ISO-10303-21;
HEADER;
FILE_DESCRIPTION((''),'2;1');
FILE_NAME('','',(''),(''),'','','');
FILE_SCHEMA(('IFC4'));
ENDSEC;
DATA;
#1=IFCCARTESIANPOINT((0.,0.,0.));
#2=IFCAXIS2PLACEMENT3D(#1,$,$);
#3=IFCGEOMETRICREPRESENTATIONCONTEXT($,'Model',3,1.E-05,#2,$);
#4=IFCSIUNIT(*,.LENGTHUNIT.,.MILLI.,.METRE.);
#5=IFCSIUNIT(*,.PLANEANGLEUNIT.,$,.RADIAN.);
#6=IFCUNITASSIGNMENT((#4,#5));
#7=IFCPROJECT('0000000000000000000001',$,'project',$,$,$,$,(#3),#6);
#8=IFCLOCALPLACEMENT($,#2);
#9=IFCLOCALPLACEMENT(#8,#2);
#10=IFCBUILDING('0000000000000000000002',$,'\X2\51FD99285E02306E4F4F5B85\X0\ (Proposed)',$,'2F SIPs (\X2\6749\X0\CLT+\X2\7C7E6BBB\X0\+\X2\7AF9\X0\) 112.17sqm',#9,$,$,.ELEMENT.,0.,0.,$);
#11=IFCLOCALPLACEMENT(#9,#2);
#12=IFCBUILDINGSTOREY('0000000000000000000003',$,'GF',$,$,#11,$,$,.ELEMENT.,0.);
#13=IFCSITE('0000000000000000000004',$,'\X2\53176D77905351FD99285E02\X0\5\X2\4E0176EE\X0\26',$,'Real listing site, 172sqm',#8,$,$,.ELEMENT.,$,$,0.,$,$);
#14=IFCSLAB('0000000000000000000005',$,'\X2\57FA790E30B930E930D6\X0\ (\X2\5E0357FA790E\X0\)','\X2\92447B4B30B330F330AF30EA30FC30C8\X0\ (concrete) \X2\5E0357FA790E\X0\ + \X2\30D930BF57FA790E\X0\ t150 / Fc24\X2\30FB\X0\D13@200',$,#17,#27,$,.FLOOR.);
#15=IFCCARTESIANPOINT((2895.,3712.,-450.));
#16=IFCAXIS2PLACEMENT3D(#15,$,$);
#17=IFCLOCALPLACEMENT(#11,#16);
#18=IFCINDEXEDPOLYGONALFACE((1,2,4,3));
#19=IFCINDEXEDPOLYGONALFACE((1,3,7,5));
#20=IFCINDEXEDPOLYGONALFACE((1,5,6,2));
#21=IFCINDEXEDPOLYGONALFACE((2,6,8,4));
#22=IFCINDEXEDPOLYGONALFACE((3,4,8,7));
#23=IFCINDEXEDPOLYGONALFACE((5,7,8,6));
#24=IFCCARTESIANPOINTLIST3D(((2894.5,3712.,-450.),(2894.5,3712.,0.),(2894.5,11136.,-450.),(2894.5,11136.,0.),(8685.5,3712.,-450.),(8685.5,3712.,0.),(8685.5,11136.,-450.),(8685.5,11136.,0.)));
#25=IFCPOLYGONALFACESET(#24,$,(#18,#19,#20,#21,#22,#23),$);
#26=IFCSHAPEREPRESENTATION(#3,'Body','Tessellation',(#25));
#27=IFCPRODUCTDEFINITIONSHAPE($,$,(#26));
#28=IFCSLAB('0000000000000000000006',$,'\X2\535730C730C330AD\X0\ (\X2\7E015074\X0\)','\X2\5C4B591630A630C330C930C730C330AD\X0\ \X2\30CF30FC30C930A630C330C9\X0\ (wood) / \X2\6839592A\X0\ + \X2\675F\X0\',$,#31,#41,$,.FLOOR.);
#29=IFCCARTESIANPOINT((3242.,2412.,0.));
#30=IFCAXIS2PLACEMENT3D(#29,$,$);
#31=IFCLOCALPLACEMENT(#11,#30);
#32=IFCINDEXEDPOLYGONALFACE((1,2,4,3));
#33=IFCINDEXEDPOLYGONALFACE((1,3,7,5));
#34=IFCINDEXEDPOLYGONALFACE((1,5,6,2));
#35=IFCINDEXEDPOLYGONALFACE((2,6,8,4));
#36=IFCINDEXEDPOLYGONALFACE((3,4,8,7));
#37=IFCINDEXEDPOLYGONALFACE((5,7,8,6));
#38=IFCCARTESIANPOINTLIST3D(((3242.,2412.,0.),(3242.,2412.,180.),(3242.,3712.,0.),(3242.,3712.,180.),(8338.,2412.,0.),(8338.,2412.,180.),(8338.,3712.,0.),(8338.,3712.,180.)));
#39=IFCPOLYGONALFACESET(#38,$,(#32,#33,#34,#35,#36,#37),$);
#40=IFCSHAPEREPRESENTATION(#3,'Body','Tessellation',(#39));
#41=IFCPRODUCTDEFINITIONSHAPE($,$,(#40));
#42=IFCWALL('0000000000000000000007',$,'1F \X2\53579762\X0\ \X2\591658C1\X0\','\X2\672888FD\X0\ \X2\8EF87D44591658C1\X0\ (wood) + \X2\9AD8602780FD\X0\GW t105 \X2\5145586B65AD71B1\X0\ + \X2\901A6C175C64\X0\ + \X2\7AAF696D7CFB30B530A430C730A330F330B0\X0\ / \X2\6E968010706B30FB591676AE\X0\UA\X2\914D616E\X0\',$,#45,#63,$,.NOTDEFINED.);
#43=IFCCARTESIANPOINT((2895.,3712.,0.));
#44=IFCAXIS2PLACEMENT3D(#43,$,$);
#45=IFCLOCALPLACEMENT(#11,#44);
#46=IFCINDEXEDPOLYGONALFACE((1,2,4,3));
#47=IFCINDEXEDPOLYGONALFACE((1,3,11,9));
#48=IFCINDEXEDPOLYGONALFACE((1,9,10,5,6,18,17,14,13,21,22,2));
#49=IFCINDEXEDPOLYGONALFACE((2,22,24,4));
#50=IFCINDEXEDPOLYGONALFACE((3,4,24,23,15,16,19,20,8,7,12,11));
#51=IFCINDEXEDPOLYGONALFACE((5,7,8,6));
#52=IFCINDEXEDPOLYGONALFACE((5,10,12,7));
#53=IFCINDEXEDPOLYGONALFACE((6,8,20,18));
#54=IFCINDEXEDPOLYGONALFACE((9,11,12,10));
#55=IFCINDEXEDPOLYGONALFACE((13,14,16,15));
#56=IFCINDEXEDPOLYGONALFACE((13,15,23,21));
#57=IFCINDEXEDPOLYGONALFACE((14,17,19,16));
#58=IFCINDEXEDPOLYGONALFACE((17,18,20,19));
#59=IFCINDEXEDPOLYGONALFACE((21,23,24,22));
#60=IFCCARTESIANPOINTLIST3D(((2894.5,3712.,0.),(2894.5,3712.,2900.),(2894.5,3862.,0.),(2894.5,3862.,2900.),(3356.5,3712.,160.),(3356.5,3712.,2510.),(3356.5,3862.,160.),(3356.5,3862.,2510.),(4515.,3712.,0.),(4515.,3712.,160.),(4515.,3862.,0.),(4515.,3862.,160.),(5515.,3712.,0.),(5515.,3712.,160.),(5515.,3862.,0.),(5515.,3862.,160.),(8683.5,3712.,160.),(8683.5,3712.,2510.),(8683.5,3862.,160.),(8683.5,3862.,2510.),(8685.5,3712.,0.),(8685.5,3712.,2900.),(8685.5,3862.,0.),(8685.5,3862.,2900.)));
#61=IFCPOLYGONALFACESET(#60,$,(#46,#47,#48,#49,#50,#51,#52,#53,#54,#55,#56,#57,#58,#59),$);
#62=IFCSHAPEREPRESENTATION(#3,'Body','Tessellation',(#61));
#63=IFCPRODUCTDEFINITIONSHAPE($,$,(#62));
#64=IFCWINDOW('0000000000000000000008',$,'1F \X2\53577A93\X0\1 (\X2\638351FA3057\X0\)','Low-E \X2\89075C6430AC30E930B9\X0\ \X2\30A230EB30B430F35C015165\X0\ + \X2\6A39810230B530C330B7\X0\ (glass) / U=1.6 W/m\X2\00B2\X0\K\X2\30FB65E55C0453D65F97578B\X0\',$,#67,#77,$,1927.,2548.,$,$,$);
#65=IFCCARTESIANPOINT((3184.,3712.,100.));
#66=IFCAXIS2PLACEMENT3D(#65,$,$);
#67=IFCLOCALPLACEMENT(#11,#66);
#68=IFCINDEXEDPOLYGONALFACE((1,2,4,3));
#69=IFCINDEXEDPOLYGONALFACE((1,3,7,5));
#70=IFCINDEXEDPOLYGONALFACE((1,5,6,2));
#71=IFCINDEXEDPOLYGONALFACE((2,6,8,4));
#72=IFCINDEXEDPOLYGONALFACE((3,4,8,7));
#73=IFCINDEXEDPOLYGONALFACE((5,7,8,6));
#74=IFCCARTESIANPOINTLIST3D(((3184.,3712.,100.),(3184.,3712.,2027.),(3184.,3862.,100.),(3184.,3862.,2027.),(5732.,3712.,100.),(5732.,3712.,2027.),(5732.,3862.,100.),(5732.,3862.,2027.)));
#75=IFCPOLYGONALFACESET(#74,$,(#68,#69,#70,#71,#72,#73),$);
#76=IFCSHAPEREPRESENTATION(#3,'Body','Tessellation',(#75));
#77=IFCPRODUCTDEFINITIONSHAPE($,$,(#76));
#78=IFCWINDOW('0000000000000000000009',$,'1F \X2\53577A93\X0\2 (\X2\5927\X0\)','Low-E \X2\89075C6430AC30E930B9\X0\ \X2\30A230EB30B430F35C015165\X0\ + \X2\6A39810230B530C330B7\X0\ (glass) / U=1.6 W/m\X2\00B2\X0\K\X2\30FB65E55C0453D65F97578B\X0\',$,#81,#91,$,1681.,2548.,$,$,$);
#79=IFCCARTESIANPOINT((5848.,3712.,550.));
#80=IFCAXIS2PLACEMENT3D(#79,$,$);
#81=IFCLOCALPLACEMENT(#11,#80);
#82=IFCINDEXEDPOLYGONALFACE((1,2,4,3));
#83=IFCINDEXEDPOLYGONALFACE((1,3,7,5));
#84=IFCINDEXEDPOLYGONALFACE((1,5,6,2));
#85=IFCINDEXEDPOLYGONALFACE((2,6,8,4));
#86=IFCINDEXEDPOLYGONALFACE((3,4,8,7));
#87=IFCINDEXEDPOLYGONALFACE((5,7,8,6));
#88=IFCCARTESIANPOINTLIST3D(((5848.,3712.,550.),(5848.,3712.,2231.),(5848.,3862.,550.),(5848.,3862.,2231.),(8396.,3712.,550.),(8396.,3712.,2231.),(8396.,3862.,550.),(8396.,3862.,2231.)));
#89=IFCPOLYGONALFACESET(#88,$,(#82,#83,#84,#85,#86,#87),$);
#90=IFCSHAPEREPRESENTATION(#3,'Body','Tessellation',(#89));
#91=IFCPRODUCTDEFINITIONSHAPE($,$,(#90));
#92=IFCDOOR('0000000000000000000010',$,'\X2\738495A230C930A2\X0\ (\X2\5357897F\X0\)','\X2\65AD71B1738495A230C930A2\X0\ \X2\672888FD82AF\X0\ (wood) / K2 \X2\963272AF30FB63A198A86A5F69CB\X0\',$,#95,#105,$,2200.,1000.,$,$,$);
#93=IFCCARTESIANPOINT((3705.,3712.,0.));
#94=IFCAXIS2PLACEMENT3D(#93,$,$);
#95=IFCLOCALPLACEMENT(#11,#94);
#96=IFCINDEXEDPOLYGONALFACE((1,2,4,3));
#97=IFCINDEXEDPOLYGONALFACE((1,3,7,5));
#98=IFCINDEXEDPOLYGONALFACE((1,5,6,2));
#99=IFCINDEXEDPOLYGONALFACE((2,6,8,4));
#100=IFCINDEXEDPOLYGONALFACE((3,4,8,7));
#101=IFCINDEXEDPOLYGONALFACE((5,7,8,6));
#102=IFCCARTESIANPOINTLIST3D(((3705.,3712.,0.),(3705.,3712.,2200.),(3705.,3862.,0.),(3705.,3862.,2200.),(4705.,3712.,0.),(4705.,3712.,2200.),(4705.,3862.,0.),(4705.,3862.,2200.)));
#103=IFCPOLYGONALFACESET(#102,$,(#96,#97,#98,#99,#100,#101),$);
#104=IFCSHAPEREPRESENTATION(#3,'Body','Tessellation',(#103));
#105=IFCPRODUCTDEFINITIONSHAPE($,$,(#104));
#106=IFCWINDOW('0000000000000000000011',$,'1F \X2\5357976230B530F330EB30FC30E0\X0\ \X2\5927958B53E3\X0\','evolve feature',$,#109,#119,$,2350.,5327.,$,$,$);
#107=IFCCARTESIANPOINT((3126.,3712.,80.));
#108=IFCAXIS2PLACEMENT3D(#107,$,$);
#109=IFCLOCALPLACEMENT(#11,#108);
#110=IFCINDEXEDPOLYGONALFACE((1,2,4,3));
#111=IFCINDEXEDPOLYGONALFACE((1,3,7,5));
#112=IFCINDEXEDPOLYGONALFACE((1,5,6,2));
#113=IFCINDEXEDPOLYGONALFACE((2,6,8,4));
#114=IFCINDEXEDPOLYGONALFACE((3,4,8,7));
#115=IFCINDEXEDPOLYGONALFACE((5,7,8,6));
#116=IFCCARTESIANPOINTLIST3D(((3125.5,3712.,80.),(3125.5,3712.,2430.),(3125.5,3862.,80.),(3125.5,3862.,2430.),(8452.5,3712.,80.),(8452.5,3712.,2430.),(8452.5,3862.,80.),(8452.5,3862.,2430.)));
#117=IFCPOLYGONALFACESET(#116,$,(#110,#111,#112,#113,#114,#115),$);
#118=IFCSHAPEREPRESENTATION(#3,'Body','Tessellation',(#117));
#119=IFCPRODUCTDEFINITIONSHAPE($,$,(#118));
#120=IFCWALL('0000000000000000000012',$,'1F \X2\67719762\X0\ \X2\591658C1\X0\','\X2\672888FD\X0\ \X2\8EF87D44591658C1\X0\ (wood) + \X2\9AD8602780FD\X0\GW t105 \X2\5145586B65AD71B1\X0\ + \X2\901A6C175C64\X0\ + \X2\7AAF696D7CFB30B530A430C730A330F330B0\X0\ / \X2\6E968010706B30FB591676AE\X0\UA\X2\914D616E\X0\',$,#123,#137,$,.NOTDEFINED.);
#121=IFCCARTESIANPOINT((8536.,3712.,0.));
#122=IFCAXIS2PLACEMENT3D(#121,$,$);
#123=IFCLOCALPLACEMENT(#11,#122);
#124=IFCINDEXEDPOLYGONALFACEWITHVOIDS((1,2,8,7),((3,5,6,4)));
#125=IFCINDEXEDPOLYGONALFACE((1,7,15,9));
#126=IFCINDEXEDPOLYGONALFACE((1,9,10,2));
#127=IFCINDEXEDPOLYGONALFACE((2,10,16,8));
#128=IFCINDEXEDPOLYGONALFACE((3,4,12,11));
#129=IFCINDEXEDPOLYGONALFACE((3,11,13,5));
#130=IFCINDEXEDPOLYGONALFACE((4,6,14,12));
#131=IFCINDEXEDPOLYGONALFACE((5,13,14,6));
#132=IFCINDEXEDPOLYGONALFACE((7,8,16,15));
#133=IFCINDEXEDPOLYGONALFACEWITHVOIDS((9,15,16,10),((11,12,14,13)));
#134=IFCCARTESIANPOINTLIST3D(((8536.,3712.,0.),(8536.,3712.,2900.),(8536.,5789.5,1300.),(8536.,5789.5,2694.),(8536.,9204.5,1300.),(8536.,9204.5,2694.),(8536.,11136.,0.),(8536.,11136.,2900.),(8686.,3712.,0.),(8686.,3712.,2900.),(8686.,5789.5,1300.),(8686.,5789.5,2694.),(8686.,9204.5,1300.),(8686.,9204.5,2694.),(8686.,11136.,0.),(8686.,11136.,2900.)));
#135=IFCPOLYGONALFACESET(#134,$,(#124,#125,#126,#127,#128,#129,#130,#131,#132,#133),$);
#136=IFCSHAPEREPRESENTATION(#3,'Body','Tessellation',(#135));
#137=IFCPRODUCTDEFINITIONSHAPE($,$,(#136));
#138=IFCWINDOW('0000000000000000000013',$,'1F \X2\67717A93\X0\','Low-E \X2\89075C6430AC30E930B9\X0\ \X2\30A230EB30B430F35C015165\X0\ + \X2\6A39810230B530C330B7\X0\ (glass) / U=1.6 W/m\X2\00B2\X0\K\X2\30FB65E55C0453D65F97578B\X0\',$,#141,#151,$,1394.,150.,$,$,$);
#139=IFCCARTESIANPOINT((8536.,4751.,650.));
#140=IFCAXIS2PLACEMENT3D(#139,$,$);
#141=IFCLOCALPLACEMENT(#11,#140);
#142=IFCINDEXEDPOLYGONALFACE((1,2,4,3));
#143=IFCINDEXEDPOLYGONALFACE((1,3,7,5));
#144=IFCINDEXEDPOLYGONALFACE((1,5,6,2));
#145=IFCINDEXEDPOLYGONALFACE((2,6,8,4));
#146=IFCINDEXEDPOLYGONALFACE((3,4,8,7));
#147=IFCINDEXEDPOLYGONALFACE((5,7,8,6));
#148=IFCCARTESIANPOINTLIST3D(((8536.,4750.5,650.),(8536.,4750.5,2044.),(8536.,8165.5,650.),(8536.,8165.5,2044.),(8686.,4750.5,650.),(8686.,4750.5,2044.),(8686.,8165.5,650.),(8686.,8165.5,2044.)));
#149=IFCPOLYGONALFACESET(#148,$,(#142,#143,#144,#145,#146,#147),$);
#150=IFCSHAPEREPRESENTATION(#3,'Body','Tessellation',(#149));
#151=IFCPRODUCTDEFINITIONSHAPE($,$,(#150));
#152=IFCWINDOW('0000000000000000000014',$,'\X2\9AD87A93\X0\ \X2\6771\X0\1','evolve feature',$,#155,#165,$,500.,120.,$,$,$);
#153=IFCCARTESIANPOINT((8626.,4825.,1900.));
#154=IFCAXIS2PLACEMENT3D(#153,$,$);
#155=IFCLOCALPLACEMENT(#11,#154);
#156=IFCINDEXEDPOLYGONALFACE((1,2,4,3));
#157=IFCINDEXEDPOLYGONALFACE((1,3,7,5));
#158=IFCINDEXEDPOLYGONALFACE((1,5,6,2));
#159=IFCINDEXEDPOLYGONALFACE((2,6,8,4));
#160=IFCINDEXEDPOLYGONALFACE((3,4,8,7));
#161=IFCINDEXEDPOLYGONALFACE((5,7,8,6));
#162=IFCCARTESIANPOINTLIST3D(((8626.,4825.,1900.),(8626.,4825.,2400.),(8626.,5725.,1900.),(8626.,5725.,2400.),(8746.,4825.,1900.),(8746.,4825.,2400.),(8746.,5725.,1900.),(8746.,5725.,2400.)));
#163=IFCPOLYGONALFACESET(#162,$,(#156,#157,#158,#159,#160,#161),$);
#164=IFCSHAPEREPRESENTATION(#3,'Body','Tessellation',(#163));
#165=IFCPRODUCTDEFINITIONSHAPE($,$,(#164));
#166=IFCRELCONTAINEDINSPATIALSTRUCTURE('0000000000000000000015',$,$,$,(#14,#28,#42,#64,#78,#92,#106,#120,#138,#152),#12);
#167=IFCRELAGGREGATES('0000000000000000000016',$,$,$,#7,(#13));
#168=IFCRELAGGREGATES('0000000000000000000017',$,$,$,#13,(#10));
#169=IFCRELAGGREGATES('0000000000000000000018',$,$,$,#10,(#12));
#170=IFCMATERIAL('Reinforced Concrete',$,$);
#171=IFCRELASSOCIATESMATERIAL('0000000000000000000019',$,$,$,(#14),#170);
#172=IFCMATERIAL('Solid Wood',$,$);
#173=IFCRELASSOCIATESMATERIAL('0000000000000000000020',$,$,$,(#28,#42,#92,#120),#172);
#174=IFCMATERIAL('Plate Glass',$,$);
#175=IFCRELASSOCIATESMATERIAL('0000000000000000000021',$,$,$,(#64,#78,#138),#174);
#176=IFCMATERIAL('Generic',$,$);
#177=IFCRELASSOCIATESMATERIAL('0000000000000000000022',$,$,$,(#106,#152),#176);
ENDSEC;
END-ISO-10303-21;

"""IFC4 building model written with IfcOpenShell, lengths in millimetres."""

from ifc_helpers import new_model, si_unit, frame, frame_2d, origin, place, context, project, spatial, rectangle, extrude, material, element, fill, save


model = new_model("IFC4")

# Units and contexts
model_context = context("Model", 3, precision=1e-05, world=origin())
ifc_project = project(units=[si_unit("LENGTHUNIT", "METRE", prefix="MILLI"), si_unit("PLANEANGLEUNIT", "RADIAN")], contexts=[model_context])

# Site, building, storey
site_placement = place(None, origin())
site = spatial("IfcSite", under=ifc_project, at=site_placement, Name="北海道函館市5丁目26", ObjectType="Real listing site, 172sqm", CompositionType="ELEMENT", RefElevation=0.0)
building_placement = place(site_placement, origin())
building = spatial("IfcBuilding", under=site, at=building_placement, Name="函館市の住宅 (Proposed)", ObjectType="2F SIPs (杉CLT+籾殻+竹) 112.17sqm", CompositionType="ELEMENT", ElevationOfRefHeight=0.0, ElevationOfTerrain=0.0)
storey_placement = place(building_placement, origin())
storey = spatial("IfcBuildingStorey", under=building, at=storey_placement, Name="GF", CompositionType="ELEMENT", Elevation=0.0)

# Slabs
ifc_material_1 = material(Name="Reinforced Concrete")
slab_1_placement = place(storey_placement, frame((2895.0, 3712.0, -450.0)))
element("IfcSlab", 1, at=slab_1_placement, inside=storey, material=ifc_material_1, Name="基礎スラブ (布基礎)", Description="鉄筋コンクリート (concrete) 布基礎 + ベタ基礎 t150 / Fc24・D13@200", PredefinedType="FLOOR", context=model_context, shape_type="SweptSolid", body=[
    extrude(rectangle(XDim=5791.0, YDim=7424.0, at=frame_2d((2895.0, 3712.0))), frame((2895.0, 3712.0, -450.0)), (0.0, 0.0, 1.0), 450.0),
])
ifc_material_2 = material(Name="Solid Wood")
slab_2_placement = place(storey_placement, frame((3242.0, 2412.0, 0.0)))
element("IfcSlab", 2, at=slab_2_placement, inside=storey, material=ifc_material_2, Name="南デッキ (縁側)", Description="屋外ウッドデッキ ハードウッド (wood) / 根太 + 束", PredefinedType="FLOOR", context=model_context, shape_type="SweptSolid", body=[
    extrude(rectangle(XDim=5096.0, YDim=1300.0, at=frame_2d((2548.0, 650.0))), frame((3242.0, 2412.0, 0.0)), (0.0, 0.0, 1.0), 180.0),
])
ifc_material_3 = material(Name="Generic")

# Wall, openings, windows, door
wall_1_placement = place(storey_placement, frame((2895.0, 3712.0, 0.0)))
wall_1 = element("IfcWall", 3, at=wall_1_placement, inside=storey, material=ifc_material_2, Name="1F 南面 外壁", Description="木製 軸組外壁 (wood) + 高性能GW t105 充填断熱 + 通気層 + 窯業系サイディング / 準耐火・外皮UA配慮", PredefinedType="NOTDEFINED", context=model_context, shape_type="SweptSolid", body=[
    extrude(rectangle(XDim=5791.0, YDim=150.0, at=frame_2d((2895.0, 75.0))), frame((2895.0, 3712.0, 0.0)), (0.0, 0.0, 1.0), 2900.0),
])
opening_1_placement = place(storey_placement, frame((3184.0, 3712.0, 100.0)))
opening_1 = element("IfcOpeningElement", 4, at=opening_1_placement, cuts=wall_1, PredefinedType="NOTDEFINED", context=model_context, shape_type="SweptSolid", body=[
    extrude(rectangle(XDim=2548.0, YDim=150.0, at=frame_2d((1274.0, 75.0))), frame((3184.0, 3712.0, 100.0)), (0.0, 0.0, 1.0), 1927.0),
])
opening_2_placement = place(storey_placement, frame((5848.0, 3712.0, 550.0)))
opening_2 = element("IfcOpeningElement", 5, at=opening_2_placement, cuts=wall_1, PredefinedType="NOTDEFINED", context=model_context, shape_type="SweptSolid", body=[
    extrude(rectangle(XDim=2548.0, YDim=150.0, at=frame_2d((1274.0, 75.0))), frame((5848.0, 3712.0, 550.0)), (0.0, 0.0, 1.0), 1681.0),
])
opening_3_placement = place(storey_placement, frame((3705.0, 3712.0, 0.0)))
opening_3 = element("IfcOpeningElement", 6, at=opening_3_placement, cuts=wall_1, PredefinedType="NOTDEFINED", context=model_context, shape_type="SweptSolid", body=[
    extrude(rectangle(XDim=1000.0, YDim=150.0, at=frame_2d((500.0, 75.0))), frame((3705.0, 3712.0, 0.0)), (0.0, 0.0, 1.0), 2200.0),
])
opening_4_placement = place(storey_placement, frame((3126.0, 3712.0, 80.0)))
opening_4 = element("IfcOpeningElement", 7, at=opening_4_placement, cuts=wall_1, PredefinedType="NOTDEFINED", context=model_context, shape_type="SweptSolid", body=[
    extrude(rectangle(XDim=5327.0, YDim=150.0, at=frame_2d((2663.0, 75.0))), frame((3126.0, 3712.0, 80.0)), (0.0, 0.0, 1.0), 2350.0),
])
ifc_material_4 = material(Name="Plate Glass")
window_1_placement = place(storey_placement, frame((3184.0, 3712.0, 100.0)))
window_1 = element("IfcWindow", 8, at=window_1_placement, inside=storey, material=ifc_material_4, Name="1F 南窓1 (掃出し)", Description="Low-E 複層ガラス アルゴン封入 + 樹脂サッシ (glass) / U=1.6 W/m²K・日射取得型", OverallHeight=1927.0, OverallWidth=2548.0, context=model_context, shape_type="SweptSolid", body=[
    extrude(rectangle(XDim=2548.0, YDim=150.0, at=frame_2d((1274.0, 75.0))), frame((3184.0, 3712.0, 100.0)), (0.0, 0.0, 1.0), 1927.0),
])
fill(opening_1, window_1)
window_2_placement = place(storey_placement, frame((5848.0, 3712.0, 550.0)))
window_2 = element("IfcWindow", 9, at=window_2_placement, inside=storey, material=ifc_material_4, Name="1F 南窓2 (大)", Description="Low-E 複層ガラス アルゴン封入 + 樹脂サッシ (glass) / U=1.6 W/m²K・日射取得型", OverallHeight=1681.0, OverallWidth=2548.0, context=model_context, shape_type="SweptSolid", body=[
    extrude(rectangle(XDim=2548.0, YDim=150.0, at=frame_2d((1274.0, 75.0))), frame((5848.0, 3712.0, 550.0)), (0.0, 0.0, 1.0), 1681.0),
])
fill(opening_2, window_2)
door_placement = place(storey_placement, frame((3705.0, 3712.0, 0.0)))
door = element("IfcDoor", 10, at=door_placement, inside=storey, material=ifc_material_2, Name="玄関ドア (南西)", Description="断熱玄関ドア 木製芯 (wood) / K2 防犯・採風機構", OverallHeight=2200.0, OverallWidth=1000.0, context=model_context, shape_type="SweptSolid", body=[
    extrude(rectangle(XDim=1000.0, YDim=150.0, at=frame_2d((500.0, 75.0))), frame((3705.0, 3712.0, 0.0)), (0.0, 0.0, 1.0), 2200.0),
])
fill(opening_3, door)
window_3_placement = place(storey_placement, frame((3126.0, 3712.0, 80.0)))
window_3 = element("IfcWindow", 11, at=window_3_placement, inside=storey, material=ifc_material_3, Name="1F 南面サンルーム 大開口", Description="evolve feature", OverallHeight=2350.0, OverallWidth=5327.0, context=model_context, shape_type="SweptSolid", body=[
    extrude(rectangle(XDim=5327.0, YDim=150.0, at=frame_2d((2663.0, 75.0))), frame((3126.0, 3712.0, 80.0)), (0.0, 0.0, 1.0), 2350.0),
])
fill(opening_4, window_3)

# Wall, openings, windows
wall_2_placement = place(storey_placement, frame((8536.0, 3712.0, 0.0)))
wall_2 = element("IfcWall", 12, at=wall_2_placement, inside=storey, material=ifc_material_2, Name="1F 東面 外壁", Description="木製 軸組外壁 (wood) + 高性能GW t105 充填断熱 + 通気層 + 窯業系サイディング / 準耐火・外皮UA配慮", PredefinedType="NOTDEFINED", context=model_context, shape_type="SweptSolid", body=[
    extrude(rectangle(XDim=150.0, YDim=7424.0, at=frame_2d((75.0, 3712.0))), frame((8536.0, 3712.0, 0.0)), (0.0, 0.0, 1.0), 2900.0),
])
opening_5_placement = place(storey_placement, frame((8536.0, 4751.0, 650.0)))
opening_5 = element("IfcOpeningElement", 13, at=opening_5_placement, cuts=wall_2, PredefinedType="NOTDEFINED", context=model_context, shape_type="SweptSolid", body=[
    extrude(rectangle(XDim=150.0, YDim=3415.0, at=frame_2d((75.0, 1707.0))), frame((8536.0, 4751.0, 650.0)), (0.0, 0.0, 1.0), 1394.0),
])
opening_6_placement = place(storey_placement, frame((8626.0, 4825.0, 1900.0)))
opening_6 = element("IfcOpeningElement", 14, at=opening_6_placement, cuts=wall_2, PredefinedType="NOTDEFINED", context=model_context, shape_type="SweptSolid", body=[
    extrude(rectangle(XDim=120.0, YDim=900.0, at=frame_2d((60.0, 450.0))), frame((8626.0, 4825.0, 1900.0)), (0.0, 0.0, 1.0), 500.0),
])
window_4_placement = place(storey_placement, frame((8536.0, 4751.0, 650.0)))
window_4 = element("IfcWindow", 15, at=window_4_placement, inside=storey, material=ifc_material_4, Name="1F 東窓", Description="Low-E 複層ガラス アルゴン封入 + 樹脂サッシ (glass) / U=1.6 W/m²K・日射取得型", OverallHeight=1394.0, OverallWidth=150.0, context=model_context, shape_type="SweptSolid", body=[
    extrude(rectangle(XDim=150.0, YDim=3415.0, at=frame_2d((75.0, 1707.0))), frame((8536.0, 4751.0, 650.0)), (0.0, 0.0, 1.0), 1394.0),
])
fill(opening_5, window_4)
window_5_placement = place(storey_placement, frame((8626.0, 4825.0, 1900.0)))
window_5 = element("IfcWindow", 16, at=window_5_placement, inside=storey, material=ifc_material_3, Name="高窓 東1", Description="evolve feature", OverallHeight=500.0, OverallWidth=120.0, context=model_context, shape_type="SweptSolid", body=[
    extrude(rectangle(XDim=120.0, YDim=900.0, at=frame_2d((60.0, 450.0))), frame((8626.0, 4825.0, 1900.0)), (0.0, 0.0, 1.0), 500.0),
])
fill(opening_6, window_5)

save(model, "model.ifc")
